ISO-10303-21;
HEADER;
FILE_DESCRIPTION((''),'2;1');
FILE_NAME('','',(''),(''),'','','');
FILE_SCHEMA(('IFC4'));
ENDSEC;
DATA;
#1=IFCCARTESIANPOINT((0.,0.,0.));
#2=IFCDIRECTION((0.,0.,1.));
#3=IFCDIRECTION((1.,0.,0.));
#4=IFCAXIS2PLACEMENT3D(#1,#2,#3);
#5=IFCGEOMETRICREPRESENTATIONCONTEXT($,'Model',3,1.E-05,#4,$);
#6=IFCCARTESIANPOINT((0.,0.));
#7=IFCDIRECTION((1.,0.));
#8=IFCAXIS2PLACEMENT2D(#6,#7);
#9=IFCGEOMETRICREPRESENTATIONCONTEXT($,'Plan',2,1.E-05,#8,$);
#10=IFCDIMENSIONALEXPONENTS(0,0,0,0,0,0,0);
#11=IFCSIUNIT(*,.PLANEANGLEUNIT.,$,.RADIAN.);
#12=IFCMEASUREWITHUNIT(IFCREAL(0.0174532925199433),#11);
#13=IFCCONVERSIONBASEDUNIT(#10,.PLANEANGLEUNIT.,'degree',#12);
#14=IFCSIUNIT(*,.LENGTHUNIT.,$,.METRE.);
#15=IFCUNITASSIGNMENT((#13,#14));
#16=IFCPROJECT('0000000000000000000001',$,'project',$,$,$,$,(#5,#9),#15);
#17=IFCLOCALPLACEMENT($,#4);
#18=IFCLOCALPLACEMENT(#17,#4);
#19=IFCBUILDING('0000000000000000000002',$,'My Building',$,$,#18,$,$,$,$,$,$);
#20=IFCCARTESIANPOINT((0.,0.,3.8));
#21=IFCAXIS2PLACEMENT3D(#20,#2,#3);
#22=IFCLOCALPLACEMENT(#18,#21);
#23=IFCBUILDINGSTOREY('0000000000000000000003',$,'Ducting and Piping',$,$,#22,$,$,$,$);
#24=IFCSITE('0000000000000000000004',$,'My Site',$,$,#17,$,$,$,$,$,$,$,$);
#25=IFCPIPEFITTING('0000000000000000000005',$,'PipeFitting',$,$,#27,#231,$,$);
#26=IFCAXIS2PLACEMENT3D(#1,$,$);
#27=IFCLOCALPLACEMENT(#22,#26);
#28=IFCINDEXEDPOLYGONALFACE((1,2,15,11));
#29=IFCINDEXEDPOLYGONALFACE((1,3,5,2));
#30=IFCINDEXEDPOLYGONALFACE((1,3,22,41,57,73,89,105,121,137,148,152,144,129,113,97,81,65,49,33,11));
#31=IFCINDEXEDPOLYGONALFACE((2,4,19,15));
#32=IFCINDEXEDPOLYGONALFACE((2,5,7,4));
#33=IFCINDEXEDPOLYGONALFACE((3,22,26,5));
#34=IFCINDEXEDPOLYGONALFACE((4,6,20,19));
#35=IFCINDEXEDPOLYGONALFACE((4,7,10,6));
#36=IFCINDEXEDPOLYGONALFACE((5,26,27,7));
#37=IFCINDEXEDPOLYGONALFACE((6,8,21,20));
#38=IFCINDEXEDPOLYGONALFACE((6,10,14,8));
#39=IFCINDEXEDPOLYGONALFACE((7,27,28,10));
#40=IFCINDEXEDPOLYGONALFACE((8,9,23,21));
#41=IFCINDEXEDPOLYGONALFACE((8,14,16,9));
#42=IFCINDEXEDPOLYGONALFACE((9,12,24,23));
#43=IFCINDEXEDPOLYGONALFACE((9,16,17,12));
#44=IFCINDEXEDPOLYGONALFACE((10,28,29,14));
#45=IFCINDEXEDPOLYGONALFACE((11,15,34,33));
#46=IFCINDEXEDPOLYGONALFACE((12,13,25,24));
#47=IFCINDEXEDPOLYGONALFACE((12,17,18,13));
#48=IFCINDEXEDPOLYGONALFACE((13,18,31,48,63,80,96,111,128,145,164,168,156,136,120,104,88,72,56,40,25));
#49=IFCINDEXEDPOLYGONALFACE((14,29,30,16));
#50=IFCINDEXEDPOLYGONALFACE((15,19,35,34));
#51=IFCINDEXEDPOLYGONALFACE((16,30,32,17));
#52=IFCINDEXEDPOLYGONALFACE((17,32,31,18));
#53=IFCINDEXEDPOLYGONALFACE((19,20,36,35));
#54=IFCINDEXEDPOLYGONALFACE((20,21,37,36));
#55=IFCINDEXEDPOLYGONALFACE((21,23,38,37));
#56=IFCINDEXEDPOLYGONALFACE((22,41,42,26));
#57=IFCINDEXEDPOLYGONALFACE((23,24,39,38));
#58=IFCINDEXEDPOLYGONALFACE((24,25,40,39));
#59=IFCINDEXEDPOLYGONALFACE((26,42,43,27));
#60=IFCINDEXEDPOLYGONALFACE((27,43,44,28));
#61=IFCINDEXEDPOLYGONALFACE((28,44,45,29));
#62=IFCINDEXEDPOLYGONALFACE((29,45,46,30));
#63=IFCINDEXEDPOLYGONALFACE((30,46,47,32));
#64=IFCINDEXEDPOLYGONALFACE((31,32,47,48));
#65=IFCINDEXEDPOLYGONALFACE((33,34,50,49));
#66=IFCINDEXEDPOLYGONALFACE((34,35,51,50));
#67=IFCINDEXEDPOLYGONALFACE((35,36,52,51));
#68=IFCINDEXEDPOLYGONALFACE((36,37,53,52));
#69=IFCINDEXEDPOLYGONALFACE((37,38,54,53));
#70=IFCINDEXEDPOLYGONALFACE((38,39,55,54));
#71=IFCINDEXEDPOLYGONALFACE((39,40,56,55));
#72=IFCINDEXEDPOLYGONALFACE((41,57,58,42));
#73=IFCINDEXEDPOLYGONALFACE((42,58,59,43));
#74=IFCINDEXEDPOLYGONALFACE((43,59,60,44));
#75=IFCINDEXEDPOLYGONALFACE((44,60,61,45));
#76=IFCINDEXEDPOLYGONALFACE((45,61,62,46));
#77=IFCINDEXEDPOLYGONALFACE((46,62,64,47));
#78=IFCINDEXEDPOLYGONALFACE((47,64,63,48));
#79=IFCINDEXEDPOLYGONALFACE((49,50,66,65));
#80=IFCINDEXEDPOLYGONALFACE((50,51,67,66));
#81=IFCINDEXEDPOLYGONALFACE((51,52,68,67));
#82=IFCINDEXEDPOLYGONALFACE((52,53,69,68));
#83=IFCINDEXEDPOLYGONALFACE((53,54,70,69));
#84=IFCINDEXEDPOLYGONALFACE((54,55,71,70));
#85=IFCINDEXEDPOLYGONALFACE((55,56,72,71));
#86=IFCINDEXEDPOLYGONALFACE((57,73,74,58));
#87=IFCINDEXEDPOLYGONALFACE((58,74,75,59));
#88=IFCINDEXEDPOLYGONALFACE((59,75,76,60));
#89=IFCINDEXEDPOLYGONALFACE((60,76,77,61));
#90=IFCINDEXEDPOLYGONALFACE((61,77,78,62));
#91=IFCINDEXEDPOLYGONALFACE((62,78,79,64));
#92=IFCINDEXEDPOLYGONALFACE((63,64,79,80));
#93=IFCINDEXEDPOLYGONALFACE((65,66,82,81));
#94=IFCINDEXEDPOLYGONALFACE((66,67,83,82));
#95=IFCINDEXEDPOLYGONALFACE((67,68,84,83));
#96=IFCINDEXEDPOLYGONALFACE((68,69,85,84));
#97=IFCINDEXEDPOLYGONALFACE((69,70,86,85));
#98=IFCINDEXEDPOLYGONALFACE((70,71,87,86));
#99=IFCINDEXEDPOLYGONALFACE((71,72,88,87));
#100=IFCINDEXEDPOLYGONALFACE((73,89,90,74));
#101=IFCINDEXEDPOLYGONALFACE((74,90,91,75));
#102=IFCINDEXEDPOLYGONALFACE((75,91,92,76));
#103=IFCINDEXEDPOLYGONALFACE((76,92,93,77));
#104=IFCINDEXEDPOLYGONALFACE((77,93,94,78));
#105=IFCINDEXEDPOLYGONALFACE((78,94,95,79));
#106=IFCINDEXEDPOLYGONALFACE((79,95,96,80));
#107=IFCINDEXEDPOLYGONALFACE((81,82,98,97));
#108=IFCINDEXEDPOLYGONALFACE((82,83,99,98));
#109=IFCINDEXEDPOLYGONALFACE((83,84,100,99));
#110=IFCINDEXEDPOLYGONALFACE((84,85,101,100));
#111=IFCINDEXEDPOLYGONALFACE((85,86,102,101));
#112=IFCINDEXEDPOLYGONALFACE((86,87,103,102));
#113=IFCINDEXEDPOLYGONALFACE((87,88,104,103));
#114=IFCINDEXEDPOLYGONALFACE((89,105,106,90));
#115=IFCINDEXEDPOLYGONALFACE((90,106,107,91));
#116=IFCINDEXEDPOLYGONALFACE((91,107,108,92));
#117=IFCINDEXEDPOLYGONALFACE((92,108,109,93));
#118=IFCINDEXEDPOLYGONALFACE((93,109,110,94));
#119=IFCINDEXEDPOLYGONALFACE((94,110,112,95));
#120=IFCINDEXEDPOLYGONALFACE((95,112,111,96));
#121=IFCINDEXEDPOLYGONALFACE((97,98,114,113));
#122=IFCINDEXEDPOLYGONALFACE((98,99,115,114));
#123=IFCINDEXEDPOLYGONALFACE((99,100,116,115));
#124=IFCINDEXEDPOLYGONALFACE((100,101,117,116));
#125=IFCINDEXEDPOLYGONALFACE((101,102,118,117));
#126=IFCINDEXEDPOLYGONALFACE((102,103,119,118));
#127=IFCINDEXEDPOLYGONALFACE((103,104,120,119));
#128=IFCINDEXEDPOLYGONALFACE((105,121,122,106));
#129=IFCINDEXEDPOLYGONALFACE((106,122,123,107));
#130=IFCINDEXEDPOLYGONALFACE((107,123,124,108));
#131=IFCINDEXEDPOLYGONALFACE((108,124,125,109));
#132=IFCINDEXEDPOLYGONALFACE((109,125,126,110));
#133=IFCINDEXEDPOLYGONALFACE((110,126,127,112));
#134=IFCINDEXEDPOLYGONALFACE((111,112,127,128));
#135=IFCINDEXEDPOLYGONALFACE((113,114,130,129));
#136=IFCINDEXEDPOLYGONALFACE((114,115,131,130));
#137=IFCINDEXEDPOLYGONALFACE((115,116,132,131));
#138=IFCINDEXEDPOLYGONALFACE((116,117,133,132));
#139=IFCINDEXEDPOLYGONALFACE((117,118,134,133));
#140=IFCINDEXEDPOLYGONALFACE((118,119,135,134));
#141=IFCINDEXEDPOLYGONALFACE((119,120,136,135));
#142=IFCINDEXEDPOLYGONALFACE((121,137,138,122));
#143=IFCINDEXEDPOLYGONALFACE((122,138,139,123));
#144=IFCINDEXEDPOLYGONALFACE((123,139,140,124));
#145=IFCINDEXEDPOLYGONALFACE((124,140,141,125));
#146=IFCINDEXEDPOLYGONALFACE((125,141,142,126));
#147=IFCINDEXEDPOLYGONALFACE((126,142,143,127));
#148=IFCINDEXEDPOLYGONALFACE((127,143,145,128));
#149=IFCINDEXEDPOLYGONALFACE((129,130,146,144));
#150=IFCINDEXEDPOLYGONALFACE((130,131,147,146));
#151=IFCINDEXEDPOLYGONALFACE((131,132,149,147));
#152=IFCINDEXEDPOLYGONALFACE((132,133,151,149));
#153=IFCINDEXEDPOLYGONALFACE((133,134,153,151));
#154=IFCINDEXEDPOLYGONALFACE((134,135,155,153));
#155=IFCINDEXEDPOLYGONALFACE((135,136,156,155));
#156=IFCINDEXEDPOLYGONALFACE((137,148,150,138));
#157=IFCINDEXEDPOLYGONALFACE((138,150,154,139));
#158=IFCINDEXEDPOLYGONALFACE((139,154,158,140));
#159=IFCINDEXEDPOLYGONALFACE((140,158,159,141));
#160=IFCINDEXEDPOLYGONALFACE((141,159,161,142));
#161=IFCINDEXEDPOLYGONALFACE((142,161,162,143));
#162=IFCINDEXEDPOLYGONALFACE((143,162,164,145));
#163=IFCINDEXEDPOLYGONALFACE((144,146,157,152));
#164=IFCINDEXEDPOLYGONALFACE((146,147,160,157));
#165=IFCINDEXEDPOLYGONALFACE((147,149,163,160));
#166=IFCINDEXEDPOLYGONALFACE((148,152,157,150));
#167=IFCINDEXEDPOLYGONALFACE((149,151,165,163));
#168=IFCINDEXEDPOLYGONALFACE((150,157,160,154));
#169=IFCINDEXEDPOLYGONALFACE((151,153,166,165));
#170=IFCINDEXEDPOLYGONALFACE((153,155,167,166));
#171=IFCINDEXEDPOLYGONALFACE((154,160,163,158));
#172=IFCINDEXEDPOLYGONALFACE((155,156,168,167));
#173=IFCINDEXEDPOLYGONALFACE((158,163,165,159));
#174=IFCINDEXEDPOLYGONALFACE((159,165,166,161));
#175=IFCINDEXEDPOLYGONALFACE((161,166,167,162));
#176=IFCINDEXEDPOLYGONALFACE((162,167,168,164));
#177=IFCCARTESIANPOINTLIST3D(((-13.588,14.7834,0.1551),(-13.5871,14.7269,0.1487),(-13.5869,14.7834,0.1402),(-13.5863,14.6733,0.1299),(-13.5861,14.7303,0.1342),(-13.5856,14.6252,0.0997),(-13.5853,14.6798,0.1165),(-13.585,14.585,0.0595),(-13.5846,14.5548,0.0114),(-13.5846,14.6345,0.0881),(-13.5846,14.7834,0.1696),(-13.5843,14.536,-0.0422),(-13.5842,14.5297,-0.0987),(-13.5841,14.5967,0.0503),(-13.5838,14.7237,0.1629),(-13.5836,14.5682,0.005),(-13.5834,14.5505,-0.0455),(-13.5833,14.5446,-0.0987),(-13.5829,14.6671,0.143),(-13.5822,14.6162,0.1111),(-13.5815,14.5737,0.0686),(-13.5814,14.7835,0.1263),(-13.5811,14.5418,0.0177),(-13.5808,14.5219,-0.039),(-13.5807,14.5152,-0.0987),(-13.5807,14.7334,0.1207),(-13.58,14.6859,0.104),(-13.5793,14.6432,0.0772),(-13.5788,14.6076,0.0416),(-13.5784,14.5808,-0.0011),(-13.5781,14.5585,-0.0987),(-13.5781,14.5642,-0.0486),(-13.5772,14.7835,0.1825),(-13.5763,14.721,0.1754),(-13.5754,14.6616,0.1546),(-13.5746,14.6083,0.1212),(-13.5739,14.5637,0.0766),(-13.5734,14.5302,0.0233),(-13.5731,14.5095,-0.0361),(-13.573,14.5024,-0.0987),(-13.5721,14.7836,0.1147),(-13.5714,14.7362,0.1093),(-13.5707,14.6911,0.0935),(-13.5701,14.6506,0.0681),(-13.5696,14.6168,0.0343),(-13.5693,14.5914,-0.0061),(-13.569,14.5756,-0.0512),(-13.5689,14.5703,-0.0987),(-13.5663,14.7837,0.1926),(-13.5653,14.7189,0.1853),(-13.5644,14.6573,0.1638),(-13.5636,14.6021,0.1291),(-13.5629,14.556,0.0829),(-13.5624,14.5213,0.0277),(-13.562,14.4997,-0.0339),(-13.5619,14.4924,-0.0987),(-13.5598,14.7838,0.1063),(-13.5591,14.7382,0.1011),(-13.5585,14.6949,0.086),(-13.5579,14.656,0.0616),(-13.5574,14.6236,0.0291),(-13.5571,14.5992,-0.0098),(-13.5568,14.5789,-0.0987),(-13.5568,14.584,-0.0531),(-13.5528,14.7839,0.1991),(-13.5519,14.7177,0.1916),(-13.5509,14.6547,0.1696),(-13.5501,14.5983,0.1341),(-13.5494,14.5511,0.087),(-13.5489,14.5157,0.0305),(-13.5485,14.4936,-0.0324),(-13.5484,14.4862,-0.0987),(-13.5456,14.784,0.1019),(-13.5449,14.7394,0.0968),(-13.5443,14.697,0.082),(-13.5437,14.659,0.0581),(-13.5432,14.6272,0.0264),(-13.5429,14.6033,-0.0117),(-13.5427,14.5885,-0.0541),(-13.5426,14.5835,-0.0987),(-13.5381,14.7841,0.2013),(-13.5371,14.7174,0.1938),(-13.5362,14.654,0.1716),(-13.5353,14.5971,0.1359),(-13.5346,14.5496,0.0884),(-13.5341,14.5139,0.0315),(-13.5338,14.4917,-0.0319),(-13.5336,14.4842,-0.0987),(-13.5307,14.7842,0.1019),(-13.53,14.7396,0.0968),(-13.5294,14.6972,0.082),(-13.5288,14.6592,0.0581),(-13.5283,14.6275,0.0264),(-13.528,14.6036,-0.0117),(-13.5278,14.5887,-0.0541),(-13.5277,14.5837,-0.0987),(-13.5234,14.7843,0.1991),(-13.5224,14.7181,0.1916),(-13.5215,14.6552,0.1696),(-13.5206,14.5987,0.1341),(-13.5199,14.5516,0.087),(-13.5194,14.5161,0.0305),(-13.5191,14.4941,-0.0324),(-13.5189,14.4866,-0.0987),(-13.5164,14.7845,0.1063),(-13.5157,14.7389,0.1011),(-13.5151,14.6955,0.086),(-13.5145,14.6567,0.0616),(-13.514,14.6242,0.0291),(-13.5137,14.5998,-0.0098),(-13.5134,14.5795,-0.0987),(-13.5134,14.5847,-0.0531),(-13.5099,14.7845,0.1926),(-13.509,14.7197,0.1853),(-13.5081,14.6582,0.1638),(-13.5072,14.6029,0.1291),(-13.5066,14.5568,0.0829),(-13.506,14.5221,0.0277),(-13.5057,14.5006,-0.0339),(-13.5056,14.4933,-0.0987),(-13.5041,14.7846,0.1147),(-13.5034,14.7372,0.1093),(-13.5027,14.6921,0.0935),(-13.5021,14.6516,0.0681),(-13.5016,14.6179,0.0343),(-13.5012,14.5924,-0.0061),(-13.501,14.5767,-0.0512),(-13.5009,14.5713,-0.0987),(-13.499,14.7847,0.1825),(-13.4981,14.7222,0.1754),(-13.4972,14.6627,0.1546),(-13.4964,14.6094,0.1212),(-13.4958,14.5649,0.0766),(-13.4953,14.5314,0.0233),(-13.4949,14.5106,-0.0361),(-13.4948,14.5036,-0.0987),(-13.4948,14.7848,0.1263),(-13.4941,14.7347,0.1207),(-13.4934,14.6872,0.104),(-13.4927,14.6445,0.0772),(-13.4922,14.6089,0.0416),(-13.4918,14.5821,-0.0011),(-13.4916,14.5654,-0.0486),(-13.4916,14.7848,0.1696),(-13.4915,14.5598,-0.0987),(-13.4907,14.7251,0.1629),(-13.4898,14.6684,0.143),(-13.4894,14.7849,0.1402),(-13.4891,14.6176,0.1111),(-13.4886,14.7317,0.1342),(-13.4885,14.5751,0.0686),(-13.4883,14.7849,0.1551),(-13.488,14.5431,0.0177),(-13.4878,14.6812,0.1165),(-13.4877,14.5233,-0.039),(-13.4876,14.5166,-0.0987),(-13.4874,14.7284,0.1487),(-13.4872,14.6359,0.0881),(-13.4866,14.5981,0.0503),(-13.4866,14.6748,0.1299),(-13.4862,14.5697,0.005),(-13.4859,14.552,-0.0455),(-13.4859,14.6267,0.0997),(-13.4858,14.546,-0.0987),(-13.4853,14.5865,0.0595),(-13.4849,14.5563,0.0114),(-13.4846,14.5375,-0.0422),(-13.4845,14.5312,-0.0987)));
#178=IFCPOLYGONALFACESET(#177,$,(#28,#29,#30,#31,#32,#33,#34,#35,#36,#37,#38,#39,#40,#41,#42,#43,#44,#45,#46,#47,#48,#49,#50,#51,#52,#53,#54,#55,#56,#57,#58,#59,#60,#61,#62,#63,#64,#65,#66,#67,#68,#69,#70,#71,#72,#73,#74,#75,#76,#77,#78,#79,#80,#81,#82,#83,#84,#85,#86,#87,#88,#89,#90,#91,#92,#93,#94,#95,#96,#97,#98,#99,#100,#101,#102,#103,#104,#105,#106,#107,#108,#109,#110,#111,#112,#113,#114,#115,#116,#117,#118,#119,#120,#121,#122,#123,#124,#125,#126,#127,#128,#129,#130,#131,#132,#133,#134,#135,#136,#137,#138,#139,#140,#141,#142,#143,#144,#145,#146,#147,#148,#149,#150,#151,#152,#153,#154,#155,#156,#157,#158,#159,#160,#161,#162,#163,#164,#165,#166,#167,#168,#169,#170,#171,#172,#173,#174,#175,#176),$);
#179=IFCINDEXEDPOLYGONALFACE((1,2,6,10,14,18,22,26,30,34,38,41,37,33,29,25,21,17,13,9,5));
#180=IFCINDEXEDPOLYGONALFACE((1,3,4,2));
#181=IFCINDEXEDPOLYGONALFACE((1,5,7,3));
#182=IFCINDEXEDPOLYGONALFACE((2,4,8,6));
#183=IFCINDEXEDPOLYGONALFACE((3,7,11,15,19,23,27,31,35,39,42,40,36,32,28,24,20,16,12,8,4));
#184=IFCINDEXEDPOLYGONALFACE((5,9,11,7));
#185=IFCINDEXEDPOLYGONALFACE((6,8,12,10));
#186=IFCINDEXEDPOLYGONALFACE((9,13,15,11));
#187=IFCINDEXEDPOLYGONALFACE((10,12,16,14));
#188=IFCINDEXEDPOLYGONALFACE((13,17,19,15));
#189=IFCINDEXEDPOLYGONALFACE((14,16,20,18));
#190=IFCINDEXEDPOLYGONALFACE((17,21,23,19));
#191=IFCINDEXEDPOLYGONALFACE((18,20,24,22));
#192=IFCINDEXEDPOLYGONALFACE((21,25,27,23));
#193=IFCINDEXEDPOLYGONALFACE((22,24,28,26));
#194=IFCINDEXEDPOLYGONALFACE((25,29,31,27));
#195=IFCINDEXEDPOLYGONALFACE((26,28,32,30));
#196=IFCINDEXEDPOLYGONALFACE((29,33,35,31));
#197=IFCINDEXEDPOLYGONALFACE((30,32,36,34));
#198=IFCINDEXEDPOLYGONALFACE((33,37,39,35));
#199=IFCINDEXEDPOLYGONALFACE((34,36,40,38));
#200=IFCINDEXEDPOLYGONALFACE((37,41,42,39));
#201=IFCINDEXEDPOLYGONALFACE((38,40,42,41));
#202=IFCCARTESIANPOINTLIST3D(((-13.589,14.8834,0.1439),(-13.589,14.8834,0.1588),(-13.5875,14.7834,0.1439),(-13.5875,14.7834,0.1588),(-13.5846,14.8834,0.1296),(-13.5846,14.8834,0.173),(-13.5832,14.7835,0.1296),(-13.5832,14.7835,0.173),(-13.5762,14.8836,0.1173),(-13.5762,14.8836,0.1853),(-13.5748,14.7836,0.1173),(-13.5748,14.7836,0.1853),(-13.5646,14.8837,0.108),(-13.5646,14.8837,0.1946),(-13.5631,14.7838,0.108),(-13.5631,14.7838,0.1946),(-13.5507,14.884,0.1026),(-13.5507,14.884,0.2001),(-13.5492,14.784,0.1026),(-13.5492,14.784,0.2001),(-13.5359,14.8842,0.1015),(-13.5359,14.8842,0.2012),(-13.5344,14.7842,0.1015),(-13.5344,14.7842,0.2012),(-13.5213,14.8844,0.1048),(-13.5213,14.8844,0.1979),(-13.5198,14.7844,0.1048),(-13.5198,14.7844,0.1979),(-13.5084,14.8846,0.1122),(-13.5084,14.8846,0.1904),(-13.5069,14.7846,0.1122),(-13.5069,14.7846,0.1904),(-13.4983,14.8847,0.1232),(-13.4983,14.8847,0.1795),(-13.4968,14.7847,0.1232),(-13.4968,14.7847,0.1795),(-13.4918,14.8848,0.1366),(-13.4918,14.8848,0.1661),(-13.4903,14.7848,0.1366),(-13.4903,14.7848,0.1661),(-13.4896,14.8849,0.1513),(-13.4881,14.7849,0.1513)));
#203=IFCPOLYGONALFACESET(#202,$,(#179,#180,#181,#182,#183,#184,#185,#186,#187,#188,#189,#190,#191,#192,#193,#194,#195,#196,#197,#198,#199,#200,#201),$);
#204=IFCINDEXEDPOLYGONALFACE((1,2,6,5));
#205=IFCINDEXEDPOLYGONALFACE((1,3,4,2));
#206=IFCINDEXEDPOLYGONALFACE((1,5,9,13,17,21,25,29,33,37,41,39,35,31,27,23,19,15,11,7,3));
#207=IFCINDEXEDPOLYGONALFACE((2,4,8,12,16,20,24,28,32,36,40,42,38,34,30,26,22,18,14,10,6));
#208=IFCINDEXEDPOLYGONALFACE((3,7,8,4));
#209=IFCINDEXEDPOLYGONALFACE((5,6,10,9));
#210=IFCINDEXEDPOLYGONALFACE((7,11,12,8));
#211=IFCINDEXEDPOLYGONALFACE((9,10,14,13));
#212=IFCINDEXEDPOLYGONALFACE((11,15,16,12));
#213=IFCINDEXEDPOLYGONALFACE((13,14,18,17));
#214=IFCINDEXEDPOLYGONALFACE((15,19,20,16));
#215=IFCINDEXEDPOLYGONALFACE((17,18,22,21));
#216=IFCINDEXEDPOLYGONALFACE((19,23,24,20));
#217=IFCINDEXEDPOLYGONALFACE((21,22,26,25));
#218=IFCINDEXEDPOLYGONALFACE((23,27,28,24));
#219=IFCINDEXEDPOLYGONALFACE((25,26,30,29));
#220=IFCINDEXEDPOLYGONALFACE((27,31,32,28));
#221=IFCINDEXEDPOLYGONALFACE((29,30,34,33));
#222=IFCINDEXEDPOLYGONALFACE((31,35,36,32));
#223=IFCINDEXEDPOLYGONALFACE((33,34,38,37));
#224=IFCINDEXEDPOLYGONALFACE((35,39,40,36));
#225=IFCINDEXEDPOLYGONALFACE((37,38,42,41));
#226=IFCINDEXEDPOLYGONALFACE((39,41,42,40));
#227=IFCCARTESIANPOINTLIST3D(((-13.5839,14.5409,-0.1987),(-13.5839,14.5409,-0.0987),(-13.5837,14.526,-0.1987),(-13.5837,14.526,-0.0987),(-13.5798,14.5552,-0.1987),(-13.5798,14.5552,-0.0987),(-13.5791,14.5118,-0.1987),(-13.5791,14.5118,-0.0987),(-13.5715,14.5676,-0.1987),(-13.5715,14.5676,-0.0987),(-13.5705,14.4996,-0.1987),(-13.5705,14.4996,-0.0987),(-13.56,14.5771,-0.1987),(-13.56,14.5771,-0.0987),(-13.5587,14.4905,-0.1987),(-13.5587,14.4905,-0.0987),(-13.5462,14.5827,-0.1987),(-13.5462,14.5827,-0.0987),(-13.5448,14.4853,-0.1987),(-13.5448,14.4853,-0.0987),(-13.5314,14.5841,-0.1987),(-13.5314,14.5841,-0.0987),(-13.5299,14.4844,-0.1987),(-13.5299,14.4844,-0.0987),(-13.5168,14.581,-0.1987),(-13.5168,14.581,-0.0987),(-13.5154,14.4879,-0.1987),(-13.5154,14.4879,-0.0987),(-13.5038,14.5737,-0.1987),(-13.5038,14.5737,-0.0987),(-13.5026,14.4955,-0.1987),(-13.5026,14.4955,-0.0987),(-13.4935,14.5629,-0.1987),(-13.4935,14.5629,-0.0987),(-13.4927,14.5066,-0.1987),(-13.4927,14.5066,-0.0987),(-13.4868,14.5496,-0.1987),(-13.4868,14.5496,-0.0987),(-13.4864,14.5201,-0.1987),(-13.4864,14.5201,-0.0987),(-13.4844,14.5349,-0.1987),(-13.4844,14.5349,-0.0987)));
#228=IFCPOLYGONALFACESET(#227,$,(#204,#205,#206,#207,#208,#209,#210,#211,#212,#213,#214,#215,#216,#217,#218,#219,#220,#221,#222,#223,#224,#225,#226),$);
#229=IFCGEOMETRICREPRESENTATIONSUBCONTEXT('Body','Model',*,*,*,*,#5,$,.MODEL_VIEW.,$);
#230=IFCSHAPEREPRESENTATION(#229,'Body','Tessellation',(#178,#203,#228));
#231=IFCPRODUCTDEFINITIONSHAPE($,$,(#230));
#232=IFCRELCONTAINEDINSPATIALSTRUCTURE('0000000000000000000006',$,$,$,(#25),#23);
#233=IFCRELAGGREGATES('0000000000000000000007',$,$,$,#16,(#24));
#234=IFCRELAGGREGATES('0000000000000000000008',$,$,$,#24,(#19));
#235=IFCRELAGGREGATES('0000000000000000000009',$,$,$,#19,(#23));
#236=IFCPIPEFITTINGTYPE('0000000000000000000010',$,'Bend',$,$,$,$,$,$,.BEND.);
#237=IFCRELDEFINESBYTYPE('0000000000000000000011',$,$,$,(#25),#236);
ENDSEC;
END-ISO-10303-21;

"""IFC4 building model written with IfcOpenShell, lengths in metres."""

from ifc_helpers import new_model, entity, si_unit, converted_unit, frame, origin_with_axes, origin_2d_with_axis, place, context, subcontext, project, spatial, circle, extrude, source, transform, mapped, type_object, type_shapes, element, save


model = new_model("IFC4")

# Units and contexts
model_context = context("Model", 3, precision=1e-05, world=origin_with_axes())
plan_context = context("Plan", 2, precision=1e-05, world=origin_2d_with_axis())
body_context = subcontext(model_context, "Body", "Model", "MODEL_VIEW")
ifc_project = project(units=[converted_unit("PLANEANGLEUNIT", "degree", entity("IfcReal", 0.0174532925199433), si_unit("PLANEANGLEUNIT", "RADIAN"), dimensions=[0, 0, 0, 0, 0, 0, 0]), si_unit("LENGTHUNIT", "METRE")], contexts=[model_context, plan_context])

# Site, building, storey
site_placement = place(None, origin_with_axes())
site = spatial("IfcSite", under=ifc_project, at=site_placement, Name="My Site")
building_placement = place(site_placement, origin_with_axes())
building = spatial("IfcBuilding", under=site, at=building_placement, Name="My Building")
storey_placement = place(building_placement, frame((0.0, 0.0, 3.8), z_axis=(0.0, 0.0, 1.0), x_axis=(1.0, 0.0, 0.0)))
storey = spatial("IfcBuildingStorey", under=building, at=storey_placement, Name="Ducting and Piping")

# Pipe fitting
pipe_fitting_type = type_object("IfcPipeFittingType", Name="Bend", PredefinedType="BEND")
shared_shape = source(origin_with_axes(), body_context, "Body", "SolidModel", [
    entity("IfcSweptDiskSolid", entity("IfcIndexedPolyCurve", entity("IfcCartesianPointList3D", [[0.0, 0.0, 0.1], [0.0, -0.0732, 0.2768], [0.0, -0.25, 0.35]]), [entity("IfcArcIndex", [1, 2, 3])]), 0.05),
    extrude(circle(Radius=0.05), origin_with_axes(), (0.0, 0.0, 1.0), 0.1),
    extrude(circle(Radius=0.05), frame((0.0, -0.25, 0.35), z_axis=(0.0, -1.0, 0.0), x_axis=(1.0, 0.0, 0.0)), (0.0, 0.0, 1.0), 0.1),
])
type_shapes(pipe_fitting_type, [shared_shape])
for number, where, z_axis, x_axis, name in (
    (1, (-13.5396, 14.8841, 0.1513), (0.014879, -0.999889, 0.0), (0.999889, 0.014879, 0.0), "PipeFitting"),
):
    element("IfcPipeFitting", number, at=place(storey_placement, frame(where, z_axis=z_axis, x_axis=x_axis)), inside=storey, type_object=pipe_fitting_type, Name=name, context=body_context, shape_type="MappedRepresentation", body=[
        mapped(shared_shape, transform((0.0, 0.0, 0.0), x_axis=(1.0, 0.0, 0.0), y_axis=(0.0, 1.0, 0.0), z_axis=(0.0, 0.0, 1.0), scale=1.0)),
    ])

save(model, "model.ifc")
